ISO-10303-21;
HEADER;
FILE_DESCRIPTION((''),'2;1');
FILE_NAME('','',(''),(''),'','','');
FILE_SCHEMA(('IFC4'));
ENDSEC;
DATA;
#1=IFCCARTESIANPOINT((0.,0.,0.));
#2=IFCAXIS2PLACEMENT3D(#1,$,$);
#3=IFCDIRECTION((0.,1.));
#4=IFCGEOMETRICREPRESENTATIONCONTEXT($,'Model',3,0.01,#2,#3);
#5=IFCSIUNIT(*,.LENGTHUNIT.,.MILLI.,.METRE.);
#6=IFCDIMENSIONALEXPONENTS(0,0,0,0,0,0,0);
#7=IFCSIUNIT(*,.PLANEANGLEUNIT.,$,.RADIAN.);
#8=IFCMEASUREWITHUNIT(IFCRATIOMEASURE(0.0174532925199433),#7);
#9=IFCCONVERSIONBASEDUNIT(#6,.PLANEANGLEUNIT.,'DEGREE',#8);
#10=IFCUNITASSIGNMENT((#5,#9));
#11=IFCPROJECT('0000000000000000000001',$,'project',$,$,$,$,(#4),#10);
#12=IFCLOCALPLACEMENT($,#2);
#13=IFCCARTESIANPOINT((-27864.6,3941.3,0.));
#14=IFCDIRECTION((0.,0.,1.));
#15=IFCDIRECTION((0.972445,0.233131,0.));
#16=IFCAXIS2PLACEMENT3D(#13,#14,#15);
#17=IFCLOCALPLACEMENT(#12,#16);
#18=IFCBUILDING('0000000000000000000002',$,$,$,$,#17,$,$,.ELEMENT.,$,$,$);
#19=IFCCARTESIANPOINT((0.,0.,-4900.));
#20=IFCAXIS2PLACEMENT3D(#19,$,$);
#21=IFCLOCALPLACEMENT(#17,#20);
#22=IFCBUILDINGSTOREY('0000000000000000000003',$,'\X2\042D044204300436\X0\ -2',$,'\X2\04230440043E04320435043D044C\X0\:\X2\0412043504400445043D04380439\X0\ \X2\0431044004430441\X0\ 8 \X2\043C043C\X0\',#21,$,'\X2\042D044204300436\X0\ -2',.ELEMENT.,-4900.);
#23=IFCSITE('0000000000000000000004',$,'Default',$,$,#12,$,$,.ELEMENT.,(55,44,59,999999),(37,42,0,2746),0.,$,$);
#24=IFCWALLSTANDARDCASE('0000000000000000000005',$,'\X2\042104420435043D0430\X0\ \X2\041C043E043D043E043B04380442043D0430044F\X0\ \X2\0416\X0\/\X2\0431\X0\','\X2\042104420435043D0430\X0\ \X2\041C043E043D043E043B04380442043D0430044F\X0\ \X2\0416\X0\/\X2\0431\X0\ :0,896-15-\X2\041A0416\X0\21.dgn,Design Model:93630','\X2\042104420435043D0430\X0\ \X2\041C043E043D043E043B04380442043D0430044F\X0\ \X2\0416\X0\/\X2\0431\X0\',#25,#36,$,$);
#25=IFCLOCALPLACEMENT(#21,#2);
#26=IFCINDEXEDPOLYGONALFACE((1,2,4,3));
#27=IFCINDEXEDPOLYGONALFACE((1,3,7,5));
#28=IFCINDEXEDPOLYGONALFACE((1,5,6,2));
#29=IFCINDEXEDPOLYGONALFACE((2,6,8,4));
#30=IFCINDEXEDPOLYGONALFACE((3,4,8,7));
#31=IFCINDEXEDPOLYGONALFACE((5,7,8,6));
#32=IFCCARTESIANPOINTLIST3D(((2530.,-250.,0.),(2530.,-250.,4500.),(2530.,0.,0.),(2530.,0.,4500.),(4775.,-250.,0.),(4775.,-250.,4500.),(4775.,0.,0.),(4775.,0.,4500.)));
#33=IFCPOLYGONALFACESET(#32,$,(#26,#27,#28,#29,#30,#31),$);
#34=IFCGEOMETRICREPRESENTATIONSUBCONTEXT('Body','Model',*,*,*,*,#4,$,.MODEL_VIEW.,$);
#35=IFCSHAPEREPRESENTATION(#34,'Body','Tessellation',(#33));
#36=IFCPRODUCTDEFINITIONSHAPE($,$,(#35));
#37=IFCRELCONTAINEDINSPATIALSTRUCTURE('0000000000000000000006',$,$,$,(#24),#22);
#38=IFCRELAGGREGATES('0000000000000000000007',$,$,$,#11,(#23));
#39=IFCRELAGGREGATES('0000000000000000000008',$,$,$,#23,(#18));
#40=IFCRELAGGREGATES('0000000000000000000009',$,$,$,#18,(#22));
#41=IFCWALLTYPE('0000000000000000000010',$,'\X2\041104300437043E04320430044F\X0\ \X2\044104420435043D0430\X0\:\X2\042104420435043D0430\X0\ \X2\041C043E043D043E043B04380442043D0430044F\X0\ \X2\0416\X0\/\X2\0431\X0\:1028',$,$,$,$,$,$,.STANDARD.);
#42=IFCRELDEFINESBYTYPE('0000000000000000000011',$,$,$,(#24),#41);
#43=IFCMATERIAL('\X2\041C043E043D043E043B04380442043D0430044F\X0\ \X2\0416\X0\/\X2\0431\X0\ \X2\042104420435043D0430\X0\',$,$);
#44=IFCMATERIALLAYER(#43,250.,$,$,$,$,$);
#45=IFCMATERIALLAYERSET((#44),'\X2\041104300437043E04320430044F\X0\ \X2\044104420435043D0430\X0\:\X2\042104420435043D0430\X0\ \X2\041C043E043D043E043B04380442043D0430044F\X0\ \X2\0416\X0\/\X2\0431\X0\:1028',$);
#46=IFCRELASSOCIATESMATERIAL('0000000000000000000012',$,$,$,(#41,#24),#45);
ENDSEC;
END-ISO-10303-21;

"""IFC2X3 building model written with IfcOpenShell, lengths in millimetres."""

from ifc_helpers import new_model, entity, si_unit, converted_unit, direction, frame, frame_2d, origin, place, context, subcontext, project, spatial, rectangle, extrude, material, layer, layer_set, layer_usage, type_object, element, save


model = new_model("IFC2X3")

# Units and contexts
model_context = context("Model", 3, precision=0.01, world=origin(), true_north=direction((0.0, 1.0)))
body_context = subcontext(model_context, "Body", "Model", "MODEL_VIEW")
ifc_project = project(units=[si_unit("LENGTHUNIT", "METRE", prefix="MILLI"), converted_unit("PLANEANGLEUNIT", "DEGREE", entity("IfcRatioMeasure", 0.0174532925199433), si_unit("PLANEANGLEUNIT", "RADIAN"), dimensions=[0, 0, 0, 0, 0, 0, 0])], contexts=[model_context])

# Site, building, storey
site_placement = place(None, origin())
site = spatial("IfcSite", under=ifc_project, at=site_placement, Name="Default", CompositionType="ELEMENT", RefLatitude=(55, 44, 59, 999999), RefLongitude=(37, 42, 0, 2746), RefElevation=0.0)
building_placement = place(site_placement, frame((-27864.6, 3941.3, 0.0), z_axis=(0.0, 0.0, 1.0), x_axis=(0.972445, 0.233131, 0.0)))
building = spatial("IfcBuilding", under=site, at=building_placement, CompositionType="ELEMENT")
storey_placement = place(building_placement, frame((0.0, 0.0, -4900.0)))
storey = spatial("IfcBuildingStorey", under=building, at=storey_placement, Name="Этаж -2", ObjectType="Уровень:Верхний брус 8 мм", LongName="Этаж -2", CompositionType="ELEMENT", Elevation=-4900.0)

# Shared definitions
ifc_material = material(Name="Монолитная Ж/б Стена")

# Wall
ifc_layer_1 = layer(ifc_material, 250.0)
ifc_layer_set_1 = layer_set([ifc_layer_1], Name="Базовая стена:Стена Монолитная Ж/б:1028")
ifc_layer_usage_1 = layer_usage(ifc_layer_set_1, "AXIS2", "NEGATIVE", 125.0)
wall_type_1 = type_object("IfcWallType", Name="Базовая стена:Стена Монолитная Ж/б:1028", PredefinedType="STANDARD", material=ifc_layer_set_1)
wall_1_placement = place(storey_placement, frame((4775.0, -125.0, 0.0), z_axis=(0.0, 0.0, 1.0), x_axis=(-1.0, 0.0, 0.0)))
element("IfcWallStandardCase", 1, at=wall_1_placement, inside=storey, type_object=wall_type_1, material=ifc_layer_usage_1, Name="Стена Монолитная Ж/б", Description="Стена Монолитная Ж/б :0,896-15-КЖ21.dgn,Design Model:93630", ObjectType="Стена Монолитная Ж/б", context=body_context, shape_type="SweptSolid", body=[
    extrude(rectangle(XDim=2245.0, YDim=250.0, at=frame_2d((1122.5, 0.0), x_axis=(-1.0, 0.0))), origin(), (0.0, 0.0, 1.0), 4500.0),
])

save(model, "model.ifc")
